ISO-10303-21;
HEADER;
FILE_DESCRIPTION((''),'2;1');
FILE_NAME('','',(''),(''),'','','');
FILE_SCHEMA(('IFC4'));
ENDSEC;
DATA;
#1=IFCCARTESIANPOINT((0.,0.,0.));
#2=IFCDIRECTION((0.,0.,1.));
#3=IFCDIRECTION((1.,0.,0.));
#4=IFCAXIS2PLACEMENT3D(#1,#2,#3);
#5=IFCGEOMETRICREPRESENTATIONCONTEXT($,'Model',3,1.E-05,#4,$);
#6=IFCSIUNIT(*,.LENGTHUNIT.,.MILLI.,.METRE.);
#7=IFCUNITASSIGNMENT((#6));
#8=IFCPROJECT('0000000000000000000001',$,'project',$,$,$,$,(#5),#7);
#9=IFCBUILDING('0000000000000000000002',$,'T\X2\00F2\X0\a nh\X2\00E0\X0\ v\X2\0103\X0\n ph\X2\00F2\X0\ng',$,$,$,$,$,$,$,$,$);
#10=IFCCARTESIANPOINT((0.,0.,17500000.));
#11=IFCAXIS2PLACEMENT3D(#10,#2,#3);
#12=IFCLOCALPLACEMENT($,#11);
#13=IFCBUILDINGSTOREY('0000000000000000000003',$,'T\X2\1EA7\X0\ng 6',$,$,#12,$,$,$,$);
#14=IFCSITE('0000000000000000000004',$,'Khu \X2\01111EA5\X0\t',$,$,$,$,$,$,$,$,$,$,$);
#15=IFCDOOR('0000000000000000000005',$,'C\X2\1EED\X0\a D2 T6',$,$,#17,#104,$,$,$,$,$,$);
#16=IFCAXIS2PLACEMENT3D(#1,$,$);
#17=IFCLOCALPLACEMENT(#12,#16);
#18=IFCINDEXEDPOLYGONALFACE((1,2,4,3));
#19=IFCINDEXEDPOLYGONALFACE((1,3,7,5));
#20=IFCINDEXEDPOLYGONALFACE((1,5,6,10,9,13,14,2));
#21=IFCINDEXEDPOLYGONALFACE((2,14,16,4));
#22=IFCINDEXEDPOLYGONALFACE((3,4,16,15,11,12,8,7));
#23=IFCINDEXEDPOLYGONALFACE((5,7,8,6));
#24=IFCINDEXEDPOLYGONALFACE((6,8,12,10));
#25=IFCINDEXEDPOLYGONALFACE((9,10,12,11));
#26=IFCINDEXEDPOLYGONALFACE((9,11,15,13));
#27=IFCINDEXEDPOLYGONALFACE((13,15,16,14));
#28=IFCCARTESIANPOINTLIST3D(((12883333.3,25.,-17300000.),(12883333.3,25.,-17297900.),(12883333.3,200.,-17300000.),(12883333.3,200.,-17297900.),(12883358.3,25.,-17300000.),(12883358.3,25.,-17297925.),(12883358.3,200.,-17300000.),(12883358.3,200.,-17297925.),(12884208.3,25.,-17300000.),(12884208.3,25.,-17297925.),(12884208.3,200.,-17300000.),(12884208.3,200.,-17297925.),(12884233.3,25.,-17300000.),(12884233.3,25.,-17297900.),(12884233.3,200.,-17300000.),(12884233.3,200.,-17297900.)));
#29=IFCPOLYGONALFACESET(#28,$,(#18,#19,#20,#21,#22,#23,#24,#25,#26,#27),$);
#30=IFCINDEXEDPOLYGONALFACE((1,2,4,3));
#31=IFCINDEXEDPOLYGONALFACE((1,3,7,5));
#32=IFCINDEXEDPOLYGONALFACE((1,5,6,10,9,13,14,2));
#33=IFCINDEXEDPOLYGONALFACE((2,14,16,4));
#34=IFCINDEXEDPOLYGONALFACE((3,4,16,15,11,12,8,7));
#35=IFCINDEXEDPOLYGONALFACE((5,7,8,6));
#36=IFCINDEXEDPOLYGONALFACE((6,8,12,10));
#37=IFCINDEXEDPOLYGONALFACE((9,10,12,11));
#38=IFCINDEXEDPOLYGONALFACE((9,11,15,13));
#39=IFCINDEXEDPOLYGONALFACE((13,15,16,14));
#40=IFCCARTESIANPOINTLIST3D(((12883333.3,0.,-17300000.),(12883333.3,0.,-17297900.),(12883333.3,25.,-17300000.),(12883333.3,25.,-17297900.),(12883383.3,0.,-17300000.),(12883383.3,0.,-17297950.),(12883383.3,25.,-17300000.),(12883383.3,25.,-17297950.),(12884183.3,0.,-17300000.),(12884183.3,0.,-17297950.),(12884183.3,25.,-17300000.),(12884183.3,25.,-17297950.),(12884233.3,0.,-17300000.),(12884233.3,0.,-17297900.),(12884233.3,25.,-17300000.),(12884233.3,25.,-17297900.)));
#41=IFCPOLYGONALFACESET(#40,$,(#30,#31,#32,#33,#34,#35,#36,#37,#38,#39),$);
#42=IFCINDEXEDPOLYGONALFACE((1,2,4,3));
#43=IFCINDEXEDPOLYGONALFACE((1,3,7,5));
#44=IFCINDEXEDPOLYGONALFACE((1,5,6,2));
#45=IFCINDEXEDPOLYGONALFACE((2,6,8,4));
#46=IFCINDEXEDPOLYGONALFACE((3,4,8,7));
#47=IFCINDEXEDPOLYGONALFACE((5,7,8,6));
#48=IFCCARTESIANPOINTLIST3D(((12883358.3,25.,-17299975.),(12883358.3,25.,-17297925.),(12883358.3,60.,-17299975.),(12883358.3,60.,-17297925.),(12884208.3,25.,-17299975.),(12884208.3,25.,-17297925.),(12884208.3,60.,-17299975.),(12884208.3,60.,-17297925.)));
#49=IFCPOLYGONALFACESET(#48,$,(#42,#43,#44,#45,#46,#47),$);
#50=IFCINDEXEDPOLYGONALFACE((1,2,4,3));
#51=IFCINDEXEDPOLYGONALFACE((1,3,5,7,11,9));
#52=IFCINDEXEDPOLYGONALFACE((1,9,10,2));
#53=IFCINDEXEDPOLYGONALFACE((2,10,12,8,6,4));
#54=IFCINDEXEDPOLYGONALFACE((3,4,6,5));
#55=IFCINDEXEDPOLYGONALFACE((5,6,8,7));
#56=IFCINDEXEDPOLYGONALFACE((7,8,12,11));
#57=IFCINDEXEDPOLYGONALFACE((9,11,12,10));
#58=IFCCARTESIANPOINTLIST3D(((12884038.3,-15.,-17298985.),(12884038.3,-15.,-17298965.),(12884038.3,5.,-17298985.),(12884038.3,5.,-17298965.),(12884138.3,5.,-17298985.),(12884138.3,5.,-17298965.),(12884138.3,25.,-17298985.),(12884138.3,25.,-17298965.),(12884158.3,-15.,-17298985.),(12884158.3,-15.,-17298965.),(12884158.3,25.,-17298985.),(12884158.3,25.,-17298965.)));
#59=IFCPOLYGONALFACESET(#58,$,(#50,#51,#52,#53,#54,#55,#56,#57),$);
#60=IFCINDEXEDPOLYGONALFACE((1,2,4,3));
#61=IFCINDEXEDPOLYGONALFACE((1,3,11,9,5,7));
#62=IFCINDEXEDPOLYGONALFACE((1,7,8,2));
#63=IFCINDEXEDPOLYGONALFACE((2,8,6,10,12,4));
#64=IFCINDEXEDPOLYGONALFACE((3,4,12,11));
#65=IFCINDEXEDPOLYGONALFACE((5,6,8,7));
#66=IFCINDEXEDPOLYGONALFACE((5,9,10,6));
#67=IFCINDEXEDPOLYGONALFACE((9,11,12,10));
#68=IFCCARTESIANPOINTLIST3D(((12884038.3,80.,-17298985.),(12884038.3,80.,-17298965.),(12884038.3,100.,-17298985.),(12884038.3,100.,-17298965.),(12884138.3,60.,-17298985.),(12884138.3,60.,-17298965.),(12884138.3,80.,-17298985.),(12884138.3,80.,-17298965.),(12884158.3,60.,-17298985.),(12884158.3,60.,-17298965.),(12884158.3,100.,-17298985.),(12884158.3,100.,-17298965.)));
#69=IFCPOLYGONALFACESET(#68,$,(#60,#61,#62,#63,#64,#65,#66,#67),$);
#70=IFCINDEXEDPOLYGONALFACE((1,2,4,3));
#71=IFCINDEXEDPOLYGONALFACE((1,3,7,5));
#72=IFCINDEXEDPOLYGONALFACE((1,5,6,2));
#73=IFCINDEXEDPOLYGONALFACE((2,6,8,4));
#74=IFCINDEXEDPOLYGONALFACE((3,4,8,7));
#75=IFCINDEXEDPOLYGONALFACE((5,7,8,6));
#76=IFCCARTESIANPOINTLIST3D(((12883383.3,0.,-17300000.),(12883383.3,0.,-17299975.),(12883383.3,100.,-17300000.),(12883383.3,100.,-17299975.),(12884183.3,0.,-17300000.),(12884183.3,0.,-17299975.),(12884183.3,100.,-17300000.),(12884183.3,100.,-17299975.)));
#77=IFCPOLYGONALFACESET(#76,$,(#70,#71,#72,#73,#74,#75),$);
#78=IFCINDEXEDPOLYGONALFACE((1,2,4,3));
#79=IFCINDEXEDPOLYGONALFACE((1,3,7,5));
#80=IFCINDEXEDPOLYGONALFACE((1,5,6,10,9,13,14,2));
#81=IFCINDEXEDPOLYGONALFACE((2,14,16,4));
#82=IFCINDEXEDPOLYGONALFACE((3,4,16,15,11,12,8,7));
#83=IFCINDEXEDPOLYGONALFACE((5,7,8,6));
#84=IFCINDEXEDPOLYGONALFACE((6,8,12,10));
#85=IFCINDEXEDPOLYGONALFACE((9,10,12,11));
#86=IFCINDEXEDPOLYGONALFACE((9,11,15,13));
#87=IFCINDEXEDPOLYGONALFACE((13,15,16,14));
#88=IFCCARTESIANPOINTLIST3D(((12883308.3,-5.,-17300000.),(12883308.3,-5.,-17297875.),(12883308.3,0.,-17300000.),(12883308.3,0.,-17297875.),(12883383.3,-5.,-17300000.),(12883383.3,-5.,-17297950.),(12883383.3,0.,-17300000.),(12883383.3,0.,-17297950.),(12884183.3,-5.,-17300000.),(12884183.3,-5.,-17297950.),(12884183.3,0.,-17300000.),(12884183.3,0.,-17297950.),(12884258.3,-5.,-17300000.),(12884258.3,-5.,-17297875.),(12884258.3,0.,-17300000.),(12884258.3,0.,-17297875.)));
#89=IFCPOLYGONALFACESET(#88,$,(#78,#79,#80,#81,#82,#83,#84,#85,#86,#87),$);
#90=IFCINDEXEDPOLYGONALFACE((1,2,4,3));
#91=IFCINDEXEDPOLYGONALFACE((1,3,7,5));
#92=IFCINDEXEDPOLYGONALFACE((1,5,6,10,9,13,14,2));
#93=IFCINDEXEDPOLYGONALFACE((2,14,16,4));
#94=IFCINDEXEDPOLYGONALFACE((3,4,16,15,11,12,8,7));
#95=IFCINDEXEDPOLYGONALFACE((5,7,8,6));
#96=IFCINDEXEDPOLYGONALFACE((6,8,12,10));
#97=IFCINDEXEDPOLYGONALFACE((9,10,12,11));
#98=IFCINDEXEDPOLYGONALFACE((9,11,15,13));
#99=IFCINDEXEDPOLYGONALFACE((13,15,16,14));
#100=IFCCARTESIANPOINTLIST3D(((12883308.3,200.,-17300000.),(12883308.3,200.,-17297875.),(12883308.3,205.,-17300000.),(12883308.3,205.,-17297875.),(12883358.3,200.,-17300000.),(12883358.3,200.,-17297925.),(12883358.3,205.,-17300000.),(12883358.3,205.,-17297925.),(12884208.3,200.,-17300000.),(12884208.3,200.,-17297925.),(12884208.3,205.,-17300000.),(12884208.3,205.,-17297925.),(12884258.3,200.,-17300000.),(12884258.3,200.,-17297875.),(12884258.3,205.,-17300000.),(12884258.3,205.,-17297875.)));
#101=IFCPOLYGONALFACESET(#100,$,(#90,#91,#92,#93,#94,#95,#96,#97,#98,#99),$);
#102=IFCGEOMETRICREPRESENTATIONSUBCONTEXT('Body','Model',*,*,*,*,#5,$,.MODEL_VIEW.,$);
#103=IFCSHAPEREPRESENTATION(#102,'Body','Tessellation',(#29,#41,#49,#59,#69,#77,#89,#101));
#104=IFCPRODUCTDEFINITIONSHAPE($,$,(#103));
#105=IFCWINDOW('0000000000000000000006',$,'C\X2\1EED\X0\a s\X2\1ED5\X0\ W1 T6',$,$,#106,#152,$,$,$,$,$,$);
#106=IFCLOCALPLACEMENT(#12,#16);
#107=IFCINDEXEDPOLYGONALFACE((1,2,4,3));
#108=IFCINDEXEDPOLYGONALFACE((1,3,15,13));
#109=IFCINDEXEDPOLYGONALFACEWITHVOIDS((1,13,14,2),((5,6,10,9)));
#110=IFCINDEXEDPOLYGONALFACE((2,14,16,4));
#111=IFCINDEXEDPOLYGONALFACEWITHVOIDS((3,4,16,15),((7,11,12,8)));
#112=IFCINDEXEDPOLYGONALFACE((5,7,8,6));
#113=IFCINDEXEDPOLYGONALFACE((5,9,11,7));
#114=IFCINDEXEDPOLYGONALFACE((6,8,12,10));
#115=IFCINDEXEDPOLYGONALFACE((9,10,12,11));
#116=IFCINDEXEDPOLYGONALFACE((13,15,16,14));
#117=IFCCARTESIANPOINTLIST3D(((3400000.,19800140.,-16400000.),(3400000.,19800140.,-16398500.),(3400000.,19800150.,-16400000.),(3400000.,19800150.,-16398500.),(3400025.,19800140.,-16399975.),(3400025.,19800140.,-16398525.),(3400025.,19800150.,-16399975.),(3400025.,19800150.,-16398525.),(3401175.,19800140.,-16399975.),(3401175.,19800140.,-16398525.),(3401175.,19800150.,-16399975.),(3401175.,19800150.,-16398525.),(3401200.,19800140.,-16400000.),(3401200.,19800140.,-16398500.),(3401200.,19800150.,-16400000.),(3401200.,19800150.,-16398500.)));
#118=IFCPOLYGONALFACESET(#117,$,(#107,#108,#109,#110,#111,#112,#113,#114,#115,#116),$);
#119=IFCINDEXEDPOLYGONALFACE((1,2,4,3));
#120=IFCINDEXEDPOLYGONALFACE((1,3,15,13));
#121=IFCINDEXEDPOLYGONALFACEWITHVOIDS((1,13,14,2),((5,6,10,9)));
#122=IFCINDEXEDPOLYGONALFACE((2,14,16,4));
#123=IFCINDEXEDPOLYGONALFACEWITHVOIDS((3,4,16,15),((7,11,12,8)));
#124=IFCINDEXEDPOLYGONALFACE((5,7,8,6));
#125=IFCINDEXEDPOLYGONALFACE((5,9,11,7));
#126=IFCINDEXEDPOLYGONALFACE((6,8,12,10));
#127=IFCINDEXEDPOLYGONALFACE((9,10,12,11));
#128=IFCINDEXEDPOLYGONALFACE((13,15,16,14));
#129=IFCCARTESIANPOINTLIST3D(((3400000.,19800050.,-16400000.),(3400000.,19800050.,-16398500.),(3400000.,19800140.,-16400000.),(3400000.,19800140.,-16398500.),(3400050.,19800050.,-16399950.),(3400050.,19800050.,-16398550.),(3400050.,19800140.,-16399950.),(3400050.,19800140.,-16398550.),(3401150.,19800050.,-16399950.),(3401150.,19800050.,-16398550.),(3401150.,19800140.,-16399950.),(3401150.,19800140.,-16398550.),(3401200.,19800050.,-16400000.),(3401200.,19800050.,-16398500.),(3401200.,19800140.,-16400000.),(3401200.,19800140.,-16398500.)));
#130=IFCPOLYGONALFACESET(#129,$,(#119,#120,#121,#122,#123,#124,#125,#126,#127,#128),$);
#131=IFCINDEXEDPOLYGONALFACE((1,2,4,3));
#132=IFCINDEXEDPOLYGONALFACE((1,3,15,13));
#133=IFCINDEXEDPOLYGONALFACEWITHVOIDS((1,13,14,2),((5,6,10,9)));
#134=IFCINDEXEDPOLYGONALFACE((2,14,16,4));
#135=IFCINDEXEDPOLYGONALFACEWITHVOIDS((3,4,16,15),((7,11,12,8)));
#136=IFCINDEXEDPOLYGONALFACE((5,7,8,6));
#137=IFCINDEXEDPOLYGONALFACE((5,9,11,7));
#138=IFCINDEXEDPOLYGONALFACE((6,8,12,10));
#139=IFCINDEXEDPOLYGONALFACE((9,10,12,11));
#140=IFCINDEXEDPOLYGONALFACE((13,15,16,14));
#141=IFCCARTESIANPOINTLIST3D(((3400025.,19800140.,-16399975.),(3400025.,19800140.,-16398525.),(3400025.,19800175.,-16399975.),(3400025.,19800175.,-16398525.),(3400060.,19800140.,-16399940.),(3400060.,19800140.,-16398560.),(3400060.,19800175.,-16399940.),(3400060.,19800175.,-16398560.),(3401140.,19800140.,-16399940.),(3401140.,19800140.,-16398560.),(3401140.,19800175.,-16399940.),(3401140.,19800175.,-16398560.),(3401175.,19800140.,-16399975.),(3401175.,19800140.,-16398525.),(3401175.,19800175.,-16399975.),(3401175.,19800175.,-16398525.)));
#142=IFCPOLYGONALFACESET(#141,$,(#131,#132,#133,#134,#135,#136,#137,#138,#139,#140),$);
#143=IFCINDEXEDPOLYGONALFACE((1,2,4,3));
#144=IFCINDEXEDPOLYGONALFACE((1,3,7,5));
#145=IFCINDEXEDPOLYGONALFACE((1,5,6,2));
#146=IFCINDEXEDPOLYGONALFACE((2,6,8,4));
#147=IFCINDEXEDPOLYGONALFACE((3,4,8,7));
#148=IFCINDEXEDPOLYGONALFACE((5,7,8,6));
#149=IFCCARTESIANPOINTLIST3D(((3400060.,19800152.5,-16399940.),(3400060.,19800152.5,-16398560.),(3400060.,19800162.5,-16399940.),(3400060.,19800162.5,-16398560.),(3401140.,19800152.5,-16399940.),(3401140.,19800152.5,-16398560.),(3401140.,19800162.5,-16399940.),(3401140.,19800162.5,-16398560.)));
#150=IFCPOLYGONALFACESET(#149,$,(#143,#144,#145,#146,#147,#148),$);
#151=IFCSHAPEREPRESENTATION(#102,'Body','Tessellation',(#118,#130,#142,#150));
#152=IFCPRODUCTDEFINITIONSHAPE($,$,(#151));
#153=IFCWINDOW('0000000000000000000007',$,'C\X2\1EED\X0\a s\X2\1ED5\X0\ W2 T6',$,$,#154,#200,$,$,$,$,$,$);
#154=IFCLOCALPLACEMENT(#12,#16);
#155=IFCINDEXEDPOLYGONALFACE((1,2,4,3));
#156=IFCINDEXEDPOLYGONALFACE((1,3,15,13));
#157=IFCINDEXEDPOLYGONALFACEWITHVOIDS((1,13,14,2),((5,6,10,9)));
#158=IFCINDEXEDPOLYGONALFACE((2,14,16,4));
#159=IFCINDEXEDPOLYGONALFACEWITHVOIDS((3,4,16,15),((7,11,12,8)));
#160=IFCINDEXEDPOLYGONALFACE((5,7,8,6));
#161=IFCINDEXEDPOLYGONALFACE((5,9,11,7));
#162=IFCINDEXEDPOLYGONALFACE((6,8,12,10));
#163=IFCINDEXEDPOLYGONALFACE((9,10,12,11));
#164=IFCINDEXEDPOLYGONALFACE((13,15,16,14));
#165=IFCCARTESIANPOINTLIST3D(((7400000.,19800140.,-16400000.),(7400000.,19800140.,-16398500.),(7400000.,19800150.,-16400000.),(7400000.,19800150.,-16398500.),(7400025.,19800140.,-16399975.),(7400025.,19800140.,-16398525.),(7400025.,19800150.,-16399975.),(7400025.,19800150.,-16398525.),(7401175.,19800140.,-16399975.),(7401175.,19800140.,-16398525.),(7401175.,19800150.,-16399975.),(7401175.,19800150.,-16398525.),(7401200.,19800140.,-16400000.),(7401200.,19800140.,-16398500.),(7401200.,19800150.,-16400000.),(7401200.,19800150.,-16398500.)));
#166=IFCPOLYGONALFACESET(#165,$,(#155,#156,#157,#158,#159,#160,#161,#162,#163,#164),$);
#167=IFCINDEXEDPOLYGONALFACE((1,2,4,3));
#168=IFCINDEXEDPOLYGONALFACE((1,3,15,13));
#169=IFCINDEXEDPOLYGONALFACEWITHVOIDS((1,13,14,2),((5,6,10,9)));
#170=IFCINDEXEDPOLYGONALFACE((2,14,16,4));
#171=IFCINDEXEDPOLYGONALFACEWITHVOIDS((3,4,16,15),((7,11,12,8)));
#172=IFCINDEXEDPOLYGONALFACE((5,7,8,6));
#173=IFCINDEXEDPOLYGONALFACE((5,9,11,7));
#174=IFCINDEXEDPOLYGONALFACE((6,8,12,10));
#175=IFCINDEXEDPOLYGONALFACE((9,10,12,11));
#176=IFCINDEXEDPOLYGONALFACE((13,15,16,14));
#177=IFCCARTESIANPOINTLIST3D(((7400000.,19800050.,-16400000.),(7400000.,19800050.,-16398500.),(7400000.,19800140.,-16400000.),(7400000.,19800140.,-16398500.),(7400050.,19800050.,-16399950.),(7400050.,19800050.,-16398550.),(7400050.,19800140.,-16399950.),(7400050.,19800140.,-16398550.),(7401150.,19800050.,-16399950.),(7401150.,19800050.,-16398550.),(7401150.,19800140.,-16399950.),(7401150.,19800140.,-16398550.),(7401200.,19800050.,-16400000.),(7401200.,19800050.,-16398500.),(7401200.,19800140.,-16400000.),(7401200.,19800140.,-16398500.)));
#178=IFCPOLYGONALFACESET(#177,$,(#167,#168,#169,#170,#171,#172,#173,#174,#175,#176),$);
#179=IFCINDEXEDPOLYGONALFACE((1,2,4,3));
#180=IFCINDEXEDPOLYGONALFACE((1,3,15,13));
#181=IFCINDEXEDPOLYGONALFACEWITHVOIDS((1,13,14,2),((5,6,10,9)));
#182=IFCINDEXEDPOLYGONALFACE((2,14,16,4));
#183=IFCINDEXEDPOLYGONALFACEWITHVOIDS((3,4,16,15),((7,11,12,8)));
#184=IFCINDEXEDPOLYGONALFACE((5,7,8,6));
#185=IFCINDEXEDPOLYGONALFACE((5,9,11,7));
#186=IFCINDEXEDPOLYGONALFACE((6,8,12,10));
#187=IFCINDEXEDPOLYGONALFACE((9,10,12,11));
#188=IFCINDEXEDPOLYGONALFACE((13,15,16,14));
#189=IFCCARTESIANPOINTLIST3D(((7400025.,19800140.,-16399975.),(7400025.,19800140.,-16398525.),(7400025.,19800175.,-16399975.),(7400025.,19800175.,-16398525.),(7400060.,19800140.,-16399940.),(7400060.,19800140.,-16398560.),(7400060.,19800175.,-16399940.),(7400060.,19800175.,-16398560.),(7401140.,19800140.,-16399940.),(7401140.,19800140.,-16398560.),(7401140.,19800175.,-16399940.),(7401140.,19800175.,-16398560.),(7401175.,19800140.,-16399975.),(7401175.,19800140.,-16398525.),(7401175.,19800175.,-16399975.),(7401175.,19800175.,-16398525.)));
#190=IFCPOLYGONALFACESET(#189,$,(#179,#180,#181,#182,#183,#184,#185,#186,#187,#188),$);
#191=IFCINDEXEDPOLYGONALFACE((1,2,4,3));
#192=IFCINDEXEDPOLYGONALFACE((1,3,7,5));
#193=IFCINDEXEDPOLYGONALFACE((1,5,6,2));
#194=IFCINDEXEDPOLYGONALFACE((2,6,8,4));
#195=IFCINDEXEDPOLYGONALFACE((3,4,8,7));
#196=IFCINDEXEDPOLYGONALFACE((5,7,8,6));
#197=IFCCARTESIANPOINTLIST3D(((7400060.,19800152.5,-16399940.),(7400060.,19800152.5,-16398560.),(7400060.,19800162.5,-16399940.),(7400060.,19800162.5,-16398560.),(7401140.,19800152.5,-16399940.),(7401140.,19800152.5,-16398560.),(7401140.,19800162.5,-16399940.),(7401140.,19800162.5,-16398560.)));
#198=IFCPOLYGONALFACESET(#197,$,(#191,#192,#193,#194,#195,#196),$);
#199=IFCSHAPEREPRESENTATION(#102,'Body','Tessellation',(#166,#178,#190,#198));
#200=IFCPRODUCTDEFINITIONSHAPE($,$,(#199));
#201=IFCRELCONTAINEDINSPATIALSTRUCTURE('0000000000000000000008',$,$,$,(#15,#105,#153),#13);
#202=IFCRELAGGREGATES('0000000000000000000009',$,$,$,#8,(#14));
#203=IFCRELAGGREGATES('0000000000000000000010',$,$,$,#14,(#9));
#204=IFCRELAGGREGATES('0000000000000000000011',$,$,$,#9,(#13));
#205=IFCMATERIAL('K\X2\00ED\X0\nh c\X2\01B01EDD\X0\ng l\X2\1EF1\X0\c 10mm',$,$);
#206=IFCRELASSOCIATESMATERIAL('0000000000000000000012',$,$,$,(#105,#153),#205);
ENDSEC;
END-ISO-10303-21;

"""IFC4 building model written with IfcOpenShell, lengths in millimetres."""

from ifc_helpers import new_model, si_unit, frame, origin_with_axes, place, context, subcontext, project, spatial, line, indexed_curve, outline, extrude, material, element, save


model = new_model("IFC4")

# Units and contexts
model_context = context("Model", 3, precision=1e-05, world=origin_with_axes())
body_context = subcontext(model_context, "Body", "Model", "MODEL_VIEW")
ifc_project = project(units=[si_unit("LENGTHUNIT", "METRE", prefix="MILLI")], contexts=[model_context])

# Site, building, storey
site = spatial("IfcSite", under=ifc_project, Name="Khu đất")
building = spatial("IfcBuilding", under=site, Name="Tòa nhà văn phòng")
storey_placement = place(None, frame((0.0, 0.0, 17500000.0), z_axis=(0.0, 0.0, 1.0), x_axis=(1.0, 0.0, 0.0)))
storey = spatial("IfcBuildingStorey", under=building, at=storey_placement, Name="Tầng 6")

# Door
door_1_placement = place(storey_placement, frame((12883333.3, 0.0, -17300000.0), z_axis=(0.0, 0.0, 1.0), x_axis=(1.0, 0.0, 0.0)))
element("IfcDoor", 1, at=door_1_placement, inside=storey, Name="Cửa D2 T6", context=body_context, shape_type="SolidModel", body=[
    extrude(outline(indexed_curve([(0.0, 0.0), (0.0, 2100.0), (900.0, 2100.0), (900.0, 0.0), (875.0, 0.0), (875.0, 2075.0), (25.0, 2075.0), (25.0, 0.0)], segments=[line(1, 2, 3, 4, 5, 6, 7, 8, 1)])), frame((0.0, 25.0, 0.0), z_axis=(0.0, -1.0, 0.0), x_axis=(1.0, 0.0, 0.0)), (0.0, 0.0, -1.0), 175.0),
    extrude(outline(indexed_curve([(0.0, 0.0), (0.0, 2100.0), (900.0, 2100.0), (900.0, 0.0), (850.0, 0.0), (850.0, 2050.0), (50.0, 2050.0), (50.0, 0.0)], segments=[line(1, 2, 3, 4, 5, 6, 7, 8, 1)])), frame((0.0, 0.0, 0.0), z_axis=(0.0, -1.0, 0.0), x_axis=(1.0, 0.0, 0.0)), (0.0, 0.0, -1.0), 25.0),
    extrude(outline(indexed_curve([(0.0, 0.0), (850.0, 0.0), (850.0, 35.0), (0.0, 35.0)], segments=[line(1, 2, 3, 4, 1)])), frame((25.0, 25.0, 25.0), z_axis=(0.0, 0.0, 1.0), x_axis=(1.0, 0.0, 0.0)), (0.0, 0.0, 1.0), 2050.0),
    extrude(outline(indexed_curve([(0.0, 0.0), (0.0, -40.0), (-120.0, -40.0), (-120.0, -20.0), (-20.0, -20.0), (-20.0, 0.0)], segments=[line(1, 2, 3, 4, 5, 6, 1)])), frame((825.0, 25.0, 1015.0), z_axis=(0.0, 0.0, 1.0), x_axis=(1.0, 0.0, 0.0)), (0.0, 0.0, 1.0), 20.0),
    extrude(outline(indexed_curve([(0.0, 0.0), (0.0, 40.0), (-120.0, 40.0), (-120.0, 20.0), (-20.0, 20.0), (-20.0, 0.0)], segments=[line(1, 2, 3, 4, 5, 6, 1)])), frame((825.0, 60.0, 1015.0), z_axis=(0.0, 0.0, 1.0), x_axis=(1.0, 0.0, 0.0)), (0.0, 0.0, 1.0), 20.0),
    extrude(outline(indexed_curve([(0.0, 0.0), (800.0, 0.0), (800.0, 100.0), (0.0, 100.0)], segments=[line(1, 2, 3, 4, 1)])), frame((50.0, 0.0, 0.0), z_axis=(0.0, 0.0, 1.0), x_axis=(1.0, 0.0, 0.0)), (0.0, 0.0, 1.0), 25.0),
    extrude(outline(indexed_curve([(0.0, 0.0), (0.0, 2125.0), (950.0, 2125.0), (950.0, 0.0), (875.0, 0.0), (875.0, 2050.0), (75.0, 2050.0), (75.0, 0.0)], segments=[line(1, 2, 3, 4, 5, 6, 7, 8, 1)])), frame((-25.0, -5.0, 0.0), z_axis=(0.0, -1.0, 0.0), x_axis=(1.0, 0.0, 0.0)), (0.0, 0.0, -1.0), 5.0),
    extrude(outline(indexed_curve([(0.0, 0.0), (0.0, 2125.0), (950.0, 2125.0), (950.0, 0.0), (900.0, 0.0), (900.0, 2075.0), (50.0, 2075.0), (50.0, 0.0)], segments=[line(1, 2, 3, 4, 5, 6, 7, 8, 1)])), frame((-25.0, 200.0, 0.0), z_axis=(0.0, -1.0, 0.0), x_axis=(1.0, 0.0, 0.0)), (0.0, 0.0, -1.0), 5.0),
])

# Windows
ifc_material_1 = material(Name="Kính cường lực 10mm")
for number, where, z_axis, x_axis, name in (
    (2, (3400000.0, 19800000.0, -16400000.0), (0.0, 0.0, 1.0), (1.0, 0.0, 0.0), "Cửa sổ W1 T6"),
    (3, (7400000.0, 19800000.0, -16400000.0), (0.0, 0.0, 1.0), (1.0, 0.0, 0.0), "Cửa sổ W2 T6"),
):
    element("IfcWindow", number, at=place(storey_placement, frame(where, z_axis=z_axis, x_axis=x_axis)), inside=storey, material=ifc_material_1, Name=name, context=body_context, shape_type="SolidModel", body=[
        extrude(outline(indexed_curve([(0.0, 0.0), (1200.0, 0.0), (1200.0, 1500.0), (0.0, 1500.0)], segments=[line(1, 2, 3, 4, 1)]), holes=[indexed_curve([(25.0, 25.0), (1175.0, 25.0), (1175.0, 1475.0), (25.0, 1475.0)], segments=[line(1, 2, 3, 4, 1)])]), frame((0.0, 140.0, 0.0), z_axis=(0.0, -1.0, 0.0), x_axis=(1.0, 0.0, 0.0)), (0.0, 0.0, -1.0), 10.0),
        extrude(outline(indexed_curve([(0.0, 0.0), (1200.0, 0.0), (1200.0, 1500.0), (0.0, 1500.0)], segments=[line(1, 2, 3, 4, 1)]), holes=[indexed_curve([(50.0, 50.0), (1150.0, 50.0), (1150.0, 1450.0), (50.0, 1450.0)], segments=[line(1, 2, 3, 4, 1)])]), frame((0.0, 50.0, 0.0), z_axis=(0.0, -1.0, 0.0), x_axis=(1.0, 0.0, 0.0)), (0.0, 0.0, -1.0), 90.0),
        extrude(outline(indexed_curve([(0.0, 0.0), (1150.0, 0.0), (1150.0, 1450.0), (0.0, 1450.0)], segments=[line(1, 2, 3, 4, 1)]), holes=[indexed_curve([(35.0, 35.0), (1115.0, 35.0), (1115.0, 1415.0), (35.0, 1415.0)], segments=[line(1, 2, 3, 4, 1)])]), frame((25.0, 140.0, 25.0), z_axis=(0.0, -1.0, 0.0), x_axis=(1.0, 0.0, 0.0)), (0.0, 0.0, -1.0), 35.0),
        extrude(outline(indexed_curve([(35.0, 35.0), (1115.0, 35.0), (1115.0, 1415.0), (35.0, 1415.0)], segments=[line(1, 2, 3, 4, 1)])), frame((25.0, 152.5, 25.0), z_axis=(0.0, -1.0, 0.0), x_axis=(1.0, 0.0, 0.0)), (0.0, 0.0, -1.0), 10.0),
    ])

save(model, "model.ifc")
